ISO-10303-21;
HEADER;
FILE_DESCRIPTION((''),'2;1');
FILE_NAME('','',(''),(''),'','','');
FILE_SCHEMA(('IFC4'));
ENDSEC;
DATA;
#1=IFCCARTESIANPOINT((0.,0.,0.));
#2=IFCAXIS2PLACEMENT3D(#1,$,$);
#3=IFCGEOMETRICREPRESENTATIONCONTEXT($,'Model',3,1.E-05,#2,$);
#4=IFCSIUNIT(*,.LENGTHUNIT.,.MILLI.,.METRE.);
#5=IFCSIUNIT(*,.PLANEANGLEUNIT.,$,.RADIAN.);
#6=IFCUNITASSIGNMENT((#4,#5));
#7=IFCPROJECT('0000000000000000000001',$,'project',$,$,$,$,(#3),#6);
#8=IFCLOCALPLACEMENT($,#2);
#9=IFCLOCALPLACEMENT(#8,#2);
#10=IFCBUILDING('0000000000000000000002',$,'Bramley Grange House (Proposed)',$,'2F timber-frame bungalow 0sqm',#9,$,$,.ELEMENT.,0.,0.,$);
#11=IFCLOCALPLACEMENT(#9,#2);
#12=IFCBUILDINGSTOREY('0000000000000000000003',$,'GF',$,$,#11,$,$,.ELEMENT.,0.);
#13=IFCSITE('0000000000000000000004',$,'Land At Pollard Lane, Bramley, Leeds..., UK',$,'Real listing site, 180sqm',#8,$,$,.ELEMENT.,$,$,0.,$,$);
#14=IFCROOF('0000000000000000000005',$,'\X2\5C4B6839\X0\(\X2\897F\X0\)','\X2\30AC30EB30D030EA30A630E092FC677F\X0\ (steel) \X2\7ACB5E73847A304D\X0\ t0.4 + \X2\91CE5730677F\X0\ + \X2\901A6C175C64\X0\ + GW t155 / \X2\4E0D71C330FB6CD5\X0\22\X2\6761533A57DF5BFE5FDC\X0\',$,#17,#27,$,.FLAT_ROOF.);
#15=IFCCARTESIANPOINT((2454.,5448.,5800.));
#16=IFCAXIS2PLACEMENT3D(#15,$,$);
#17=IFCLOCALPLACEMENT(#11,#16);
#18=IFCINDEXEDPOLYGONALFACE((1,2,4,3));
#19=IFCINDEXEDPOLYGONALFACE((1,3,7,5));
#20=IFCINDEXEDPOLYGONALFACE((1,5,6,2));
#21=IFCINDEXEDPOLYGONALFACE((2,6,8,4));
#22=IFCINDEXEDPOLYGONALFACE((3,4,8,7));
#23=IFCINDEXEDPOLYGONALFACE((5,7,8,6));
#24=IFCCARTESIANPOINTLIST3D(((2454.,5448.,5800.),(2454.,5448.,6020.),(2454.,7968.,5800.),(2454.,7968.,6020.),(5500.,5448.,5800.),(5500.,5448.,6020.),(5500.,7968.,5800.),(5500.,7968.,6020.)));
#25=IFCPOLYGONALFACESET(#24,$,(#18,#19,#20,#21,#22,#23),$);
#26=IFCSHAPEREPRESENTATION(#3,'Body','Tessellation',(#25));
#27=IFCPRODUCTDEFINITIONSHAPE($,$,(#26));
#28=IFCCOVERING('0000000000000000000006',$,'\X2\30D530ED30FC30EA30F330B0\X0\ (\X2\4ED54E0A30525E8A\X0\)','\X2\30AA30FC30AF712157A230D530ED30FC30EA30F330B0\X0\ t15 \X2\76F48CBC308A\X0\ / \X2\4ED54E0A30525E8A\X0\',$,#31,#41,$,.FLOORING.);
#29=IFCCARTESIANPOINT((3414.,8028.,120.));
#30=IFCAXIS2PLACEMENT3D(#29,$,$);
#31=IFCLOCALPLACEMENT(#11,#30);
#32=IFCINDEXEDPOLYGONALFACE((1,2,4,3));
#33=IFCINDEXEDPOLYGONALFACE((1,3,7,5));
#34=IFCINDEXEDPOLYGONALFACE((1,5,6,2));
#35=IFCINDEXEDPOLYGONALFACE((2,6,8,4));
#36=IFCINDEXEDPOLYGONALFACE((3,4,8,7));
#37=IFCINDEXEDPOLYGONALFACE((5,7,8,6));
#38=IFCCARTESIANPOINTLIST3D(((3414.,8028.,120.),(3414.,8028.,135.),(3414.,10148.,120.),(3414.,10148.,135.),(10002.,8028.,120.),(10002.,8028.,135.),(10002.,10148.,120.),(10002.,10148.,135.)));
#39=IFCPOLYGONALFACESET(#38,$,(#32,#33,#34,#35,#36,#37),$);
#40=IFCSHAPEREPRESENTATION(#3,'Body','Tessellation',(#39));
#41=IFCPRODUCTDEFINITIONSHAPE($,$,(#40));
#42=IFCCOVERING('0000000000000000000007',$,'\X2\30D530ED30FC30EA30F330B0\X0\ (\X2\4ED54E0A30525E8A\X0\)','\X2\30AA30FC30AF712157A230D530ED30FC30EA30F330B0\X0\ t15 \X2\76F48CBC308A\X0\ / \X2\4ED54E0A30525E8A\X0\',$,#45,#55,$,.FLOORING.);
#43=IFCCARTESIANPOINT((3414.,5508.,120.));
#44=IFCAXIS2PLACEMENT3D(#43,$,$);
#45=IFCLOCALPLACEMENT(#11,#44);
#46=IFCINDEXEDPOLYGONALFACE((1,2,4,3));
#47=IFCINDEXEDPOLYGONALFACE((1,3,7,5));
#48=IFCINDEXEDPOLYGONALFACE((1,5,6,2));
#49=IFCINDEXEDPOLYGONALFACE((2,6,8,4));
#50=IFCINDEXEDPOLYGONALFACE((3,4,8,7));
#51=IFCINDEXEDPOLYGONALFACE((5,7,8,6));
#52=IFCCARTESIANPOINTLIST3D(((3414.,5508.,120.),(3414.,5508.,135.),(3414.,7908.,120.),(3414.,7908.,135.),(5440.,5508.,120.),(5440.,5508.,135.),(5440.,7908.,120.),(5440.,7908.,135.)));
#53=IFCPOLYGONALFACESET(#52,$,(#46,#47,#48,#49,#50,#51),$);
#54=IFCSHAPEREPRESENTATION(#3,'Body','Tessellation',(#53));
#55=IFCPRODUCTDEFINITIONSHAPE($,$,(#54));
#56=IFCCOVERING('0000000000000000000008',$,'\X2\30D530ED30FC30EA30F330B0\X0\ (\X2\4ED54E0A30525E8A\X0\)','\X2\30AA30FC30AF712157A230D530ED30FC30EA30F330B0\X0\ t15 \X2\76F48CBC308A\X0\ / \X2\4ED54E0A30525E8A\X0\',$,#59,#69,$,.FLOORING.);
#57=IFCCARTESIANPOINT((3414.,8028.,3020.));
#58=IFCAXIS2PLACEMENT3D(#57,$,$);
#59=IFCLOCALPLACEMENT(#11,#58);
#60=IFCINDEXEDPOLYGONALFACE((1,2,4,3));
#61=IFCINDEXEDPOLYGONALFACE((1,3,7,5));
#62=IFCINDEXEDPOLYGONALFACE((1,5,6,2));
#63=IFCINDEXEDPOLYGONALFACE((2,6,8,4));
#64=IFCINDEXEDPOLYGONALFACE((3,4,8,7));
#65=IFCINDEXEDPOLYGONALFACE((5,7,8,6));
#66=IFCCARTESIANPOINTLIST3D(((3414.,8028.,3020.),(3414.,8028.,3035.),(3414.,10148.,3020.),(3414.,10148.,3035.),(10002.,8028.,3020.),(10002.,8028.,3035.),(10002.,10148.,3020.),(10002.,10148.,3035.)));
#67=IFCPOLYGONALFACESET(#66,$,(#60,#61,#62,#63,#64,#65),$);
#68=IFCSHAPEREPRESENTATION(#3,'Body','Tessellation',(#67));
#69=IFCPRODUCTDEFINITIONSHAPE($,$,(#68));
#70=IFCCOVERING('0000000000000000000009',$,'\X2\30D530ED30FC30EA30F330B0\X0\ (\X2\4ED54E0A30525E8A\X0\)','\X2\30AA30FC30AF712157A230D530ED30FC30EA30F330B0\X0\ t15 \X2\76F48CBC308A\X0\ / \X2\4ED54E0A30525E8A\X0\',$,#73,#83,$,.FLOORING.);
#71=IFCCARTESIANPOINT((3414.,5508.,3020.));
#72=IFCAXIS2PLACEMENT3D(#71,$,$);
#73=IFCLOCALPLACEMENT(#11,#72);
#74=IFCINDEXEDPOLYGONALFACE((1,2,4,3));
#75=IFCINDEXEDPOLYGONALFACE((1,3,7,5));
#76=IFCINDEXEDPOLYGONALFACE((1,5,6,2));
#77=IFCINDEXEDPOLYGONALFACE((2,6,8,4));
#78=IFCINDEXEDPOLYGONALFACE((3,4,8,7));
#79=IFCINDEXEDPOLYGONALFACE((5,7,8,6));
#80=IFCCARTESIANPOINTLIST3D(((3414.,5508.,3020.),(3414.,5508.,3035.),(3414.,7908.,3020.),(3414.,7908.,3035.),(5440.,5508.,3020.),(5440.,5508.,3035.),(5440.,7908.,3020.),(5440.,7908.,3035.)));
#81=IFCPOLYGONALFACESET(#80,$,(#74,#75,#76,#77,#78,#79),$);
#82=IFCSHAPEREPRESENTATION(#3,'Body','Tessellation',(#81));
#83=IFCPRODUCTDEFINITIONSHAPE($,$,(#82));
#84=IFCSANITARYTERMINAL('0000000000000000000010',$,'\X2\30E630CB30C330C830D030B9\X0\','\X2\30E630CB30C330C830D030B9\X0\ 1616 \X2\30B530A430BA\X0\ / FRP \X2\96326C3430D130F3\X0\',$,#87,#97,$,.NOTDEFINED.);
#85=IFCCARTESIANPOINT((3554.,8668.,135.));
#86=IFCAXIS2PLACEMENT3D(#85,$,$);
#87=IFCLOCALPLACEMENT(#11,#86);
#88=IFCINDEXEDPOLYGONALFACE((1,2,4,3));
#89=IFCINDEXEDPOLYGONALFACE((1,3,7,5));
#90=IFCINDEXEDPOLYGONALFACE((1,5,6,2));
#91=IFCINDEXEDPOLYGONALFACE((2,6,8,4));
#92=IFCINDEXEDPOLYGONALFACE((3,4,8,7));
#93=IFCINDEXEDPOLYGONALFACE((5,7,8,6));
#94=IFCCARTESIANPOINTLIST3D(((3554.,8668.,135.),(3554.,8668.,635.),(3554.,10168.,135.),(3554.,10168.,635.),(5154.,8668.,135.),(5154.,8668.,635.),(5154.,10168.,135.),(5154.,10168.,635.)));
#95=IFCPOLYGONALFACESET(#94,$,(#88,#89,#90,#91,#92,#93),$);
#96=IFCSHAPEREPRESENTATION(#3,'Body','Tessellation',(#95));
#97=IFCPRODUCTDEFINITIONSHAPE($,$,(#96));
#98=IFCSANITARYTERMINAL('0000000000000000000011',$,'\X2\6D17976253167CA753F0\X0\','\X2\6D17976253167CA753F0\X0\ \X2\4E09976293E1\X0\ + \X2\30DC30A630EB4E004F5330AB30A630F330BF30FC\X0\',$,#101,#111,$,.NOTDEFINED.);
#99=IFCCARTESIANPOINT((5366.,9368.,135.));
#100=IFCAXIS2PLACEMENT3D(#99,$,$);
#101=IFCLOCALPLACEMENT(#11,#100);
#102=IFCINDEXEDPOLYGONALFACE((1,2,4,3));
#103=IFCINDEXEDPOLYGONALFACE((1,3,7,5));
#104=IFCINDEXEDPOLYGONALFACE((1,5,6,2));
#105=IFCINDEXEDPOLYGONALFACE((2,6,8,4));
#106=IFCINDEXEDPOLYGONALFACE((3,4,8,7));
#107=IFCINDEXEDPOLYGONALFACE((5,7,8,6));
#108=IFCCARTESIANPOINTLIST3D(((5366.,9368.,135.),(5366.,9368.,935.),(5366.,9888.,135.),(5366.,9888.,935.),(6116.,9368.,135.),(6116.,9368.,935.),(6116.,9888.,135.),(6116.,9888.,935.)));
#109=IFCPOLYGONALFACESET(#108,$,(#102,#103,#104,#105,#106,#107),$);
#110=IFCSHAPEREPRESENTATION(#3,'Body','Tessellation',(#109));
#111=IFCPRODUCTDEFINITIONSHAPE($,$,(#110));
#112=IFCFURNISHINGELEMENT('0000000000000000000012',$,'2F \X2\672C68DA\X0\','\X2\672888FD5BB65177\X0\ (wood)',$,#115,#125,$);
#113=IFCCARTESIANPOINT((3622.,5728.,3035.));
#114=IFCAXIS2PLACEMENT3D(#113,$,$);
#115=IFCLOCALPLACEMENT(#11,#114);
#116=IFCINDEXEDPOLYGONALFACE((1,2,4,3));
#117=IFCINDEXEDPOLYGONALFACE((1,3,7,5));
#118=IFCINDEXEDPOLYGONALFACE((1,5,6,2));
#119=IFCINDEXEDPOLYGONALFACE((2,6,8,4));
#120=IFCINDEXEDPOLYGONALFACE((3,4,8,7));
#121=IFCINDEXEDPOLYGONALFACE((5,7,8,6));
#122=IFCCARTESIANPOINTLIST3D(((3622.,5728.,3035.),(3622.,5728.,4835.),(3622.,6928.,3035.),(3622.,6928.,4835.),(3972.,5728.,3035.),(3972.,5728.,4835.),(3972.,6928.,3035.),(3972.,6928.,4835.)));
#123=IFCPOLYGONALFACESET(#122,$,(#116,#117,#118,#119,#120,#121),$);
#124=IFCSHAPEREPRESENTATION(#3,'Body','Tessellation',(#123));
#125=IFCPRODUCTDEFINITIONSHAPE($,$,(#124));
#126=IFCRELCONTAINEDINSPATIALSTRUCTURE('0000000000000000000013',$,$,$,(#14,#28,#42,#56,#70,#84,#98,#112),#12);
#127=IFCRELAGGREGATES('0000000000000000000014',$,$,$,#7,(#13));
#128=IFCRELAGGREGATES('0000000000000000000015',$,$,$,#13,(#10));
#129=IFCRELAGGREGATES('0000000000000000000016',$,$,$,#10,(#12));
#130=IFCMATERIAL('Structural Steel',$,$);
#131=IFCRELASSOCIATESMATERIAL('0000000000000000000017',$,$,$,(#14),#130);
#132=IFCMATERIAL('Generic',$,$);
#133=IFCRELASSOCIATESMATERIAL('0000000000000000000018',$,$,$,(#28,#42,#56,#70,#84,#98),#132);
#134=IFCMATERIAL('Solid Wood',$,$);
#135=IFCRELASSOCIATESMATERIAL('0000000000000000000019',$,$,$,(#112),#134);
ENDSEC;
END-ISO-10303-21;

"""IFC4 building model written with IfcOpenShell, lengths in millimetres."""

from ifc_helpers import new_model, si_unit, frame, frame_2d, origin, place, context, project, spatial, rectangle, extrude, material, element, save


model = new_model("IFC4")

# Units and contexts
model_context = context("Model", 3, precision=1e-05, world=origin())
ifc_project = project(units=[si_unit("LENGTHUNIT", "METRE", prefix="MILLI"), si_unit("PLANEANGLEUNIT", "RADIAN")], contexts=[model_context])

# Site, building, storey
site_placement = place(None, origin())
site = spatial("IfcSite", under=ifc_project, at=site_placement, Name="Land At Pollard Lane, Bramley, Leeds..., UK", ObjectType="Real listing site, 180sqm", CompositionType="ELEMENT", RefElevation=0.0)
building_placement = place(site_placement, origin())
building = spatial("IfcBuilding", under=site, at=building_placement, Name="Bramley Grange House (Proposed)", ObjectType="2F timber-frame bungalow 0sqm", CompositionType="ELEMENT", ElevationOfRefHeight=0.0, ElevationOfTerrain=0.0)
storey_placement = place(building_placement, origin())
storey = spatial("IfcBuildingStorey", under=building, at=storey_placement, Name="GF", CompositionType="ELEMENT", Elevation=0.0)

# Shared definitions
ifc_material_1 = material(Name="Solid Wood")

# Roof
ifc_material_2 = material(Name="Structural Steel")
roof_placement = place(storey_placement, frame((2454.0, 5448.0, 5800.0)))
element("IfcRoof", 1, at=roof_placement, inside=storey, material=ifc_material_2, Name="屋根(西)", Description="ガルバリウム鋼板 (steel) 立平葺き t0.4 + 野地板 + 通気層 + GW t155 / 不燃・法22条区域対応", PredefinedType="FLAT_ROOF", context=model_context, shape_type="SweptSolid", body=[
    extrude(rectangle(XDim=3046.0, YDim=2520.0, at=frame_2d((1523.0, 1260.0))), frame((2454.0, 5448.0, 5800.0)), (0.0, 0.0, 1.0), 220.0),
])

# Coverings
ifc_material_3 = material(Name="Generic")
covering_1_placement = place(storey_placement, frame((3414.0, 8028.0, 120.0)))
element("IfcCovering", 2, at=covering_1_placement, inside=storey, material=ifc_material_3, Name="フローリング (仕上げ床)", Description="オーク無垢フローリング t15 直貼り / 仕上げ床", PredefinedType="FLOORING", context=model_context, shape_type="SweptSolid", body=[
    extrude(rectangle(XDim=6588.0, YDim=2120.0, at=frame_2d((3294.0, 1060.0))), frame((3414.0, 8028.0, 120.0)), (0.0, 0.0, 1.0), 15.0),
])
covering_2_placement = place(storey_placement, frame((3414.0, 5508.0, 120.0)))
element("IfcCovering", 3, at=covering_2_placement, inside=storey, material=ifc_material_3, Name="フローリング (仕上げ床)", Description="オーク無垢フローリング t15 直貼り / 仕上げ床", PredefinedType="FLOORING", context=model_context, shape_type="SweptSolid", body=[
    extrude(rectangle(XDim=2026.0, YDim=2400.0, at=frame_2d((1013.0, 1200.0))), frame((3414.0, 5508.0, 120.0)), (0.0, 0.0, 1.0), 15.0),
])
covering_3_placement = place(storey_placement, frame((3414.0, 8028.0, 3020.0)))
element("IfcCovering", 4, at=covering_3_placement, inside=storey, material=ifc_material_3, Name="フローリング (仕上げ床)", Description="オーク無垢フローリング t15 直貼り / 仕上げ床", PredefinedType="FLOORING", context=model_context, shape_type="SweptSolid", body=[
    extrude(rectangle(XDim=6588.0, YDim=2120.0, at=frame_2d((3294.0, 1060.0))), frame((3414.0, 8028.0, 3020.0)), (0.0, 0.0, 1.0), 15.0),
])
covering_4_placement = place(storey_placement, frame((3414.0, 5508.0, 3020.0)))
element("IfcCovering", 5, at=covering_4_placement, inside=storey, material=ifc_material_3, Name="フローリング (仕上げ床)", Description="オーク無垢フローリング t15 直貼り / 仕上げ床", PredefinedType="FLOORING", context=model_context, shape_type="SweptSolid", body=[
    extrude(rectangle(XDim=2026.0, YDim=2400.0, at=frame_2d((1013.0, 1200.0))), frame((3414.0, 5508.0, 3020.0)), (0.0, 0.0, 1.0), 15.0),
])

# Sanitary terminals
sanitary_terminal_1_placement = place(storey_placement, frame((3554.0, 8668.0, 135.0)))
element("IfcSanitaryTerminal", 6, at=sanitary_terminal_1_placement, inside=storey, material=ifc_material_3, Name="ユニットバス", Description="ユニットバス 1616 サイズ / FRP 防水パン", PredefinedType="NOTDEFINED", context=model_context, shape_type="SweptSolid", body=[
    extrude(rectangle(XDim=1600.0, YDim=1500.0, at=frame_2d((800.0, 750.0))), frame((3554.0, 8668.0, 135.0)), (0.0, 0.0, 1.0), 500.0),
])
sanitary_terminal_2_placement = place(storey_placement, frame((5366.0, 9368.0, 135.0)))
element("IfcSanitaryTerminal", 7, at=sanitary_terminal_2_placement, inside=storey, material=ifc_material_3, Name="洗面化粧台", Description="洗面化粧台 三面鏡 + ボウル一体カウンター", PredefinedType="NOTDEFINED", context=model_context, shape_type="SweptSolid", body=[
    extrude(rectangle(XDim=750.0, YDim=520.0, at=frame_2d((375.0, 260.0))), frame((5366.0, 9368.0, 135.0)), (0.0, 0.0, 1.0), 800.0),
])

# Furnishing element
furnishing_placement = place(storey_placement, frame((3622.0, 5728.0, 3035.0)))
element("IfcFurnishingElement", 8, at=furnishing_placement, inside=storey, material=ifc_material_1, Name="2F 本棚", Description="木製家具 (wood)", context=model_context, shape_type="SweptSolid", body=[
    extrude(rectangle(XDim=350.0, YDim=1200.0, at=frame_2d((175.0, 600.0))), frame((3622.0, 5728.0, 3035.0)), (0.0, 0.0, 1.0), 1800.0),
])

save(model, "model.ifc")
